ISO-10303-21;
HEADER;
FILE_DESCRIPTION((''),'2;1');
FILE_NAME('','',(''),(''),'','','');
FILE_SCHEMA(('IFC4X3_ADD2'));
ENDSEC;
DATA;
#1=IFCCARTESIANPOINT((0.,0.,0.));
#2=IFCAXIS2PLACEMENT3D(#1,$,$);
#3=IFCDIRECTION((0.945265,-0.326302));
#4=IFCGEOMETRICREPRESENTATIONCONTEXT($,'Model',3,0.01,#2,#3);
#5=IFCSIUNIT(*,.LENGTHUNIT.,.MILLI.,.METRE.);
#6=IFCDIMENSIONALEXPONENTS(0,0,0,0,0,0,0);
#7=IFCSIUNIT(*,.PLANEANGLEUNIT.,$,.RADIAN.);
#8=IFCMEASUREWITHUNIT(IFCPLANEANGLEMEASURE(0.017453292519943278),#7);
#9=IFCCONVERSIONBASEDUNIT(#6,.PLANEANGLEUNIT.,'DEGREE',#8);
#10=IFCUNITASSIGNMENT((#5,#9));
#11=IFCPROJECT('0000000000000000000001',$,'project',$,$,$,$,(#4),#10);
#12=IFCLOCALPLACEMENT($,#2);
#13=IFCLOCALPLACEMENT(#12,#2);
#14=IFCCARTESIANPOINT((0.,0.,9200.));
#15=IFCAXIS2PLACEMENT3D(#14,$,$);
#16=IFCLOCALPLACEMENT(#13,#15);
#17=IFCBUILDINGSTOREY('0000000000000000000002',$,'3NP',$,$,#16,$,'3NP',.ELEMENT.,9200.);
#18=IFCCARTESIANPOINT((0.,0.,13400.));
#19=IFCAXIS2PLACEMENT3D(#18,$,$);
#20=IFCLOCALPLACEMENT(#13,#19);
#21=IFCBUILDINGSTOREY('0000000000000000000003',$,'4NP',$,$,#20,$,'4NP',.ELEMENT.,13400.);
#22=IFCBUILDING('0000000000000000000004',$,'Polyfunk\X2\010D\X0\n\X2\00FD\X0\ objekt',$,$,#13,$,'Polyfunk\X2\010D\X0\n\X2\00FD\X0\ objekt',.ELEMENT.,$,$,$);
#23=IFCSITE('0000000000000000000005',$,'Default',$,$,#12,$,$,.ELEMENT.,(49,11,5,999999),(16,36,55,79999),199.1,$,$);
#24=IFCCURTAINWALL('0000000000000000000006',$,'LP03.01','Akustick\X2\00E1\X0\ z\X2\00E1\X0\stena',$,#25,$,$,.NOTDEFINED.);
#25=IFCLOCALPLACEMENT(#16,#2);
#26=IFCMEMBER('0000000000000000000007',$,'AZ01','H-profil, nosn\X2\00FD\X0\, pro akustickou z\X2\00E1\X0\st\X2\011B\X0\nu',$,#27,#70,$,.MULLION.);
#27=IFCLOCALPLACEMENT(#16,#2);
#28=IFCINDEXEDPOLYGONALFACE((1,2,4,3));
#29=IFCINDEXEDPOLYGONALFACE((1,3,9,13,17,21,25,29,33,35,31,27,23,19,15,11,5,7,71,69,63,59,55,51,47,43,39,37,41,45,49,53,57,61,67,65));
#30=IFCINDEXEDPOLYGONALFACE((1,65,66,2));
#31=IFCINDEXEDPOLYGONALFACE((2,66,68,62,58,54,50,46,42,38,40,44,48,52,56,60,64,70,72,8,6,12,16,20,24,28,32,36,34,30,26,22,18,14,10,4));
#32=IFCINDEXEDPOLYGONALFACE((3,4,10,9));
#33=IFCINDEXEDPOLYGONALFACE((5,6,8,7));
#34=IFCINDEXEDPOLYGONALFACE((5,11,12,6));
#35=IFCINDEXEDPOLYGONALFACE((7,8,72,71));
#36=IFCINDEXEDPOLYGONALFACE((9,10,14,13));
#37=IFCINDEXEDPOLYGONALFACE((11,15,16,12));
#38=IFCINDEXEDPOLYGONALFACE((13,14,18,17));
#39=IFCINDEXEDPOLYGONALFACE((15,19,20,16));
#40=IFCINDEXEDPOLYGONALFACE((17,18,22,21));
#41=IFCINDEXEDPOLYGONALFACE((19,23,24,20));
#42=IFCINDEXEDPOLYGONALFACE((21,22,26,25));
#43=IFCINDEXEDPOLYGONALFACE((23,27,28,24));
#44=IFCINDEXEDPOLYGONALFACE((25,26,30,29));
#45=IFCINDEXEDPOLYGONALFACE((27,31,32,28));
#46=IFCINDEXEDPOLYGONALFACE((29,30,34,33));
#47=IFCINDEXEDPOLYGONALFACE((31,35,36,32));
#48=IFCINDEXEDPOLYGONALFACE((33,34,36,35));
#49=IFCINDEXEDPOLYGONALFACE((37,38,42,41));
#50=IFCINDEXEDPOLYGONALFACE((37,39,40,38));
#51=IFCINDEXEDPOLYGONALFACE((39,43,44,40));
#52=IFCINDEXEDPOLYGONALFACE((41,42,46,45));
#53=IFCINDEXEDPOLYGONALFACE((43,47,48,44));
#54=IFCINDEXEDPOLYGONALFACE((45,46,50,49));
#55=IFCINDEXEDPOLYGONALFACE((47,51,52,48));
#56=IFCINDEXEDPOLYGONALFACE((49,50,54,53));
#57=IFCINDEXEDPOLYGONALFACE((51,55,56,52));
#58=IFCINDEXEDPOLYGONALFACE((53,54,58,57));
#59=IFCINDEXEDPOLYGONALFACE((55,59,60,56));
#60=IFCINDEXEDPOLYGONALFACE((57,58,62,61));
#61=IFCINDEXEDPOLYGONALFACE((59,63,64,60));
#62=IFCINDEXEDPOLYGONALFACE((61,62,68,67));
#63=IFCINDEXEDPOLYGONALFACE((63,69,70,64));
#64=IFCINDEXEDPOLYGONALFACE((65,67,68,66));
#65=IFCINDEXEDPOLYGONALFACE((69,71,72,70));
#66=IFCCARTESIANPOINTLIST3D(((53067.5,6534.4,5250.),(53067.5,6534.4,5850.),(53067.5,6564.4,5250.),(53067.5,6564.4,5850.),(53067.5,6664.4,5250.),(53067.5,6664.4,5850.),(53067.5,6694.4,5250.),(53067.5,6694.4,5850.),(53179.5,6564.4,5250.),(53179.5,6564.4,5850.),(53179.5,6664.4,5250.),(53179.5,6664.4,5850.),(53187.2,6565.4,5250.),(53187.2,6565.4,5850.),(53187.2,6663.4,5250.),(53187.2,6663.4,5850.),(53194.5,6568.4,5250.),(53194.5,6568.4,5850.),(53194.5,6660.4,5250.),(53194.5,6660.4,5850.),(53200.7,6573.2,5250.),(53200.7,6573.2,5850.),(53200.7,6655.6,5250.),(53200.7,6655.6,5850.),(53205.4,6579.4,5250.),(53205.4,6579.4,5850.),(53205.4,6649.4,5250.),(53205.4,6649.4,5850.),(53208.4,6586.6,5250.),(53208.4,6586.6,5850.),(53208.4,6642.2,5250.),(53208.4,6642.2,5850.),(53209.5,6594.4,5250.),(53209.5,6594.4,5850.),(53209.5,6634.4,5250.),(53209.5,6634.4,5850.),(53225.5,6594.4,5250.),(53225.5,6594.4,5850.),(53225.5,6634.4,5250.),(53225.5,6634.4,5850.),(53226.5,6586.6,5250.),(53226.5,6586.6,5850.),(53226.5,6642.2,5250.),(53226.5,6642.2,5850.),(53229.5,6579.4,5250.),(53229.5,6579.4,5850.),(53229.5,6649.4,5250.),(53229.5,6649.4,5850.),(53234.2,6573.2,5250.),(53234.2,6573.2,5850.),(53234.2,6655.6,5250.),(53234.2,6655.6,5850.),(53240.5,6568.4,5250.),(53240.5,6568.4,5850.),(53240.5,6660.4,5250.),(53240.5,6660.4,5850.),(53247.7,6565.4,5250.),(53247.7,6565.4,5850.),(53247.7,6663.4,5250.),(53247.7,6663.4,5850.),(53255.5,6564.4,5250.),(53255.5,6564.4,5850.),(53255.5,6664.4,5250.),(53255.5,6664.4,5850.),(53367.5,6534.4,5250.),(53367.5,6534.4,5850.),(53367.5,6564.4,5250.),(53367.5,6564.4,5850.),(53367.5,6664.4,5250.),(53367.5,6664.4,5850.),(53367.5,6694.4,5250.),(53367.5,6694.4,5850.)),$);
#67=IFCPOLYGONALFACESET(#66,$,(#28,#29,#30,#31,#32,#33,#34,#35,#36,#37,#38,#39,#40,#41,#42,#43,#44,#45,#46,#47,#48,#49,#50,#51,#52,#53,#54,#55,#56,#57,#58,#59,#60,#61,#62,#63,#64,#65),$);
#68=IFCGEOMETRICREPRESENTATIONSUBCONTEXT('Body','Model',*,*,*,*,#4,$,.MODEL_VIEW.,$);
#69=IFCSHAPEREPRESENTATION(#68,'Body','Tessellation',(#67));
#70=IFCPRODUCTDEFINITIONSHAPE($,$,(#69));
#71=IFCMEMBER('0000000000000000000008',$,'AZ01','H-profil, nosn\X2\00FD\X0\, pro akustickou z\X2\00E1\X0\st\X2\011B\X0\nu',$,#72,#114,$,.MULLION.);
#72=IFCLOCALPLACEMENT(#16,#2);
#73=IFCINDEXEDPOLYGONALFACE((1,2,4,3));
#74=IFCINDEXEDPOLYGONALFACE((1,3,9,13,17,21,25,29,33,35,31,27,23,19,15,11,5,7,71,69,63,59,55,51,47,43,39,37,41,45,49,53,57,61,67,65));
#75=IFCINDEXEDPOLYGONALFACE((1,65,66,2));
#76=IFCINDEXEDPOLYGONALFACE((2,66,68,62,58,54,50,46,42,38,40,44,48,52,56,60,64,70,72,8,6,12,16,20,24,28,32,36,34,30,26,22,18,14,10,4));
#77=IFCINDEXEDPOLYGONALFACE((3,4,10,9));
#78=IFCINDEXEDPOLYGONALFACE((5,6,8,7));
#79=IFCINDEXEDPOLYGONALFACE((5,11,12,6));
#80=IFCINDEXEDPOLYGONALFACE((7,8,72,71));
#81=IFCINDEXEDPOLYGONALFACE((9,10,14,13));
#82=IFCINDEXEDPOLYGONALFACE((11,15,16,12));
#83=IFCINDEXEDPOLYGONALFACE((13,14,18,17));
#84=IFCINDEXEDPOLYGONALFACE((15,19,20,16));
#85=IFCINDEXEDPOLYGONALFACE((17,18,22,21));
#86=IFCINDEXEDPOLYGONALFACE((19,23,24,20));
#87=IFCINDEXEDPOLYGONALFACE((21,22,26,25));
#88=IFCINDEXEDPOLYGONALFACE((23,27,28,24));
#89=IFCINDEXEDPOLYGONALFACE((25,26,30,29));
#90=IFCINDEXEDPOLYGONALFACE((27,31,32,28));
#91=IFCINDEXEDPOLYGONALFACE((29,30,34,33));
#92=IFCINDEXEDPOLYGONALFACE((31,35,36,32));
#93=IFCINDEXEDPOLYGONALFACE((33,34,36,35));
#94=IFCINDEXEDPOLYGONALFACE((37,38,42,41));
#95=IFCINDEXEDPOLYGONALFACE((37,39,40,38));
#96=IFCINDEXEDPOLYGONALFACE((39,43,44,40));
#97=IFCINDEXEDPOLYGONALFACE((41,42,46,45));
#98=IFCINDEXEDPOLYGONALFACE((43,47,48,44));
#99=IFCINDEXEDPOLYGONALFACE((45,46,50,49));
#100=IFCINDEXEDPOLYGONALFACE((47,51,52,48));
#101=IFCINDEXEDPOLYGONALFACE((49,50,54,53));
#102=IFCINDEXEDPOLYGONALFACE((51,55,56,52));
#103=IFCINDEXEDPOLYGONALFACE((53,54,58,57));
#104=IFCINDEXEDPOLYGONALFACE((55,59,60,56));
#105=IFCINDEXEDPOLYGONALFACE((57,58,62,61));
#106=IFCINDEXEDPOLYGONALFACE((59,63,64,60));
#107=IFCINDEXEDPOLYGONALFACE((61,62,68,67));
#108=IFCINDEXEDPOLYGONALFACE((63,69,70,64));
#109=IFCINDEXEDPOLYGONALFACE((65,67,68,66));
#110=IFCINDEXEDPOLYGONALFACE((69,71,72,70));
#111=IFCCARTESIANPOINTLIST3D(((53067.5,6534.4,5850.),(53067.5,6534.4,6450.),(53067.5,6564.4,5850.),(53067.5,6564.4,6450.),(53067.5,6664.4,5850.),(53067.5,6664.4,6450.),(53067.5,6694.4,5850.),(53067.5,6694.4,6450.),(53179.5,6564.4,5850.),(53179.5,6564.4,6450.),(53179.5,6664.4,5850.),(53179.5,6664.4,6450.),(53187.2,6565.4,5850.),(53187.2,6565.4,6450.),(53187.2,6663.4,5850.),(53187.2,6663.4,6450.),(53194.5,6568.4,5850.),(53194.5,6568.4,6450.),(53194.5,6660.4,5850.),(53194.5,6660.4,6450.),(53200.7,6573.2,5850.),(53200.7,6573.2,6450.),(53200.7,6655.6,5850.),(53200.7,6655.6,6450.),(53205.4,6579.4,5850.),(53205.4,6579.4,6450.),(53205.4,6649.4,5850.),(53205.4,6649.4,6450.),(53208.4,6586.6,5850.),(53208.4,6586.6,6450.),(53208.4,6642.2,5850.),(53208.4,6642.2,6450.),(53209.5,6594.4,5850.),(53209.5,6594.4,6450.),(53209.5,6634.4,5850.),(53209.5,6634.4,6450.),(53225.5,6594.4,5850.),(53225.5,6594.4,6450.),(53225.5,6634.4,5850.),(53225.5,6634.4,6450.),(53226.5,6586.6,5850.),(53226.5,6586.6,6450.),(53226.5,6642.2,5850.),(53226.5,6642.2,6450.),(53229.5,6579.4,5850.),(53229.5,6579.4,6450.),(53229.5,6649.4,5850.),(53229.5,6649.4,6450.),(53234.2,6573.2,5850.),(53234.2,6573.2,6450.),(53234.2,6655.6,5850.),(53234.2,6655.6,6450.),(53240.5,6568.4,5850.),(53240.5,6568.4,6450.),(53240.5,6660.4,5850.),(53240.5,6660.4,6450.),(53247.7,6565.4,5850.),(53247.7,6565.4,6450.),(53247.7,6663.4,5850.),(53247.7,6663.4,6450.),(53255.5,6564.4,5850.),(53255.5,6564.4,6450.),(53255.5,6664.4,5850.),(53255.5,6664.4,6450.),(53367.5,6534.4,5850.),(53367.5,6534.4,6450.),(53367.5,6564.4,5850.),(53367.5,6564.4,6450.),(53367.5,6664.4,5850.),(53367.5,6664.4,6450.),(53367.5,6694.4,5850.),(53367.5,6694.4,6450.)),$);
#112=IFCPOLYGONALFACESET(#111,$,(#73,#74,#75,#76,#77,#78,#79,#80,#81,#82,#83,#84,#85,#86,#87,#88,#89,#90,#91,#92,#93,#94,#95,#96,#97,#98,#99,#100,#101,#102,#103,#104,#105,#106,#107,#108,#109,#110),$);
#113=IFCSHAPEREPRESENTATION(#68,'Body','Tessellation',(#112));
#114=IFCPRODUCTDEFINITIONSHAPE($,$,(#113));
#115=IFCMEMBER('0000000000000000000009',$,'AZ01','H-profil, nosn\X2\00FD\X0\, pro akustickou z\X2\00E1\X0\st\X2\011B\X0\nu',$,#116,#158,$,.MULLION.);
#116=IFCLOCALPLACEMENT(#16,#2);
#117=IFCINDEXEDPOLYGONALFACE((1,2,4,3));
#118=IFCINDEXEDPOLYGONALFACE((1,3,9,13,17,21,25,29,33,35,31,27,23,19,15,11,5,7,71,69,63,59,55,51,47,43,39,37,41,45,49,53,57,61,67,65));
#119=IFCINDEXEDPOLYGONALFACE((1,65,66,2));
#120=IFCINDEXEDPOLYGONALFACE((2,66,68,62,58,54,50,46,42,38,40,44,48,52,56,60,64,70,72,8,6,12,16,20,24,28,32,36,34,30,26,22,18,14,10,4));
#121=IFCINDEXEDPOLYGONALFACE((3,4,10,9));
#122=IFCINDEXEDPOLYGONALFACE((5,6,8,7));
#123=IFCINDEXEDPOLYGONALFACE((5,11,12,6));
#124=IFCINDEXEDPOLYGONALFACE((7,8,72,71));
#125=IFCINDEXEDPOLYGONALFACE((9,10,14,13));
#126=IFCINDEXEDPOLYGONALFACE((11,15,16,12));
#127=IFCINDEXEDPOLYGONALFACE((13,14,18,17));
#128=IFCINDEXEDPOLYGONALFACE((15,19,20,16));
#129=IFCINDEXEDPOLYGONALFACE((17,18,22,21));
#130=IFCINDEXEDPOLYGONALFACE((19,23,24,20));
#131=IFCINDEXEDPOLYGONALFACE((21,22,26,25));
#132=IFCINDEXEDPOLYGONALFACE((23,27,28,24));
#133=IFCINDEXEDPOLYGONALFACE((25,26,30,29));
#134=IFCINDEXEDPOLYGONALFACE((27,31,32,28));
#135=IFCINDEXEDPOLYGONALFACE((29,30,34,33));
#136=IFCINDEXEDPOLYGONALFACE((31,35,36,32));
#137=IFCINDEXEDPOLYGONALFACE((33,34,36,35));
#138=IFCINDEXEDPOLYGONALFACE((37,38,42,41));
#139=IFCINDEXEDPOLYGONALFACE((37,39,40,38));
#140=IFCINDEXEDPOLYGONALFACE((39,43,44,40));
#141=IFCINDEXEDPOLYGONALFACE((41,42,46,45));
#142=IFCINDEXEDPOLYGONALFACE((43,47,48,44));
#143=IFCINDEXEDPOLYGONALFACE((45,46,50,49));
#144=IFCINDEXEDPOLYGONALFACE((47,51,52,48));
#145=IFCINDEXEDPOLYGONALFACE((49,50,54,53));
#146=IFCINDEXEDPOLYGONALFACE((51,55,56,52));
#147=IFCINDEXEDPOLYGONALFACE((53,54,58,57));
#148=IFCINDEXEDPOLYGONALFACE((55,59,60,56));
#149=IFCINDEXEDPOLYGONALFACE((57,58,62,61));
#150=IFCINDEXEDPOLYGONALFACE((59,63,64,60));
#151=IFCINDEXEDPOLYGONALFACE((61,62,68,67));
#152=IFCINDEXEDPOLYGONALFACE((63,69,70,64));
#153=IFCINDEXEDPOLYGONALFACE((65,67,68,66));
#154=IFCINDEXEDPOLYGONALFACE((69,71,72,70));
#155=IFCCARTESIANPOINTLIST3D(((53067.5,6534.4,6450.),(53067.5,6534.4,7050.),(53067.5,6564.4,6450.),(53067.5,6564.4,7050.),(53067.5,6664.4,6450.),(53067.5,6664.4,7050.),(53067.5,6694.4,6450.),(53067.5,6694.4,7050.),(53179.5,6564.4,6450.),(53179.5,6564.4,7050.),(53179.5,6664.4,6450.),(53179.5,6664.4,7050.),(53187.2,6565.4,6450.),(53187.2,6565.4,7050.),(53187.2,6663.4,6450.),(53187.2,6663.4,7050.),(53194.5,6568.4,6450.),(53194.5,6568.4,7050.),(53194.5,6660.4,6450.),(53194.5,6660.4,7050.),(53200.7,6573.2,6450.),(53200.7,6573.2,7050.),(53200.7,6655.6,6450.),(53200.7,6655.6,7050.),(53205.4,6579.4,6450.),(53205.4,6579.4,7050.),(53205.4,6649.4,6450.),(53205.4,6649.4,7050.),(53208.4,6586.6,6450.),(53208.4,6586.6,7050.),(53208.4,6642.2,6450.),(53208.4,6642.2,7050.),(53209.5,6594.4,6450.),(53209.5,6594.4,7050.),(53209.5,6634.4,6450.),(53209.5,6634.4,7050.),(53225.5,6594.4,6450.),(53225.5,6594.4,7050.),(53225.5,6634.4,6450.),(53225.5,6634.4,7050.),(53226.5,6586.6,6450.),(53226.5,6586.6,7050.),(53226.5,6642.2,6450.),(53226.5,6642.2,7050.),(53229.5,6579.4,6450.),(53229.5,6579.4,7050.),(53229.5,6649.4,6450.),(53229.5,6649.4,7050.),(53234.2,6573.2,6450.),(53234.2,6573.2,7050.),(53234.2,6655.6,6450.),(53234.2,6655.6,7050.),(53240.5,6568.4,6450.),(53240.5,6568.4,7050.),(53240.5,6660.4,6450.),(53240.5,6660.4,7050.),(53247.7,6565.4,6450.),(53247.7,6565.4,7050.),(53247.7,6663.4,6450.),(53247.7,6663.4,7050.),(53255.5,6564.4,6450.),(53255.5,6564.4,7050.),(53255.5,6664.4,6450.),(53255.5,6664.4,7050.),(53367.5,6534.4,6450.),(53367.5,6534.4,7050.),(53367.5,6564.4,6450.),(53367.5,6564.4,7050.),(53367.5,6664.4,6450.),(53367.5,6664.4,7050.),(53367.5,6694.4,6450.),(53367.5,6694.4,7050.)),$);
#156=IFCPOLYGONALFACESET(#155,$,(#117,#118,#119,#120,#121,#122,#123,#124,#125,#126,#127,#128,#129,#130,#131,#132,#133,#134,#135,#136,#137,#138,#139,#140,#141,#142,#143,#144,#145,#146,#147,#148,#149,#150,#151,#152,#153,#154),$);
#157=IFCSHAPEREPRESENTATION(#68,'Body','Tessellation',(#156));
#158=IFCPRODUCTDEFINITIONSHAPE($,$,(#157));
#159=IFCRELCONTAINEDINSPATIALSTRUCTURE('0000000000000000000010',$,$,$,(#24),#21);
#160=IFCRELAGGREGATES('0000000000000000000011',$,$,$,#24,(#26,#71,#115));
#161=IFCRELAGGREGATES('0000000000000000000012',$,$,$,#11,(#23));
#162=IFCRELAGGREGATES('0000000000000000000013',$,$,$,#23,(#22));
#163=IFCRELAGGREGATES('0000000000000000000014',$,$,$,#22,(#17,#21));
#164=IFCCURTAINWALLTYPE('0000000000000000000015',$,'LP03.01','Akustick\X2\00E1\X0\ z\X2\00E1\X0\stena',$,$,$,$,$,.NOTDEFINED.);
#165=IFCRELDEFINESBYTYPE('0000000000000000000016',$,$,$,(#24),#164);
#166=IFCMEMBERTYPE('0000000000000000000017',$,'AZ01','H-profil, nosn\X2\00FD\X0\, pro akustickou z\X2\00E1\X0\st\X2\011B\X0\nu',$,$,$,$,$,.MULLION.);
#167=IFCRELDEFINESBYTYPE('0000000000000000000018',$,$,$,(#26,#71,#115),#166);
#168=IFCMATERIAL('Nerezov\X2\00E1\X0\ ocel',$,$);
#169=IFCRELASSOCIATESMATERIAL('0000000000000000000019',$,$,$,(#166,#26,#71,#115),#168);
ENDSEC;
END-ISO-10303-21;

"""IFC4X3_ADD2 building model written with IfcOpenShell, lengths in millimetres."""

from ifc_helpers import new_model, entity, si_unit, converted_unit, direction, frame, frame_2d, origin, place, context, subcontext, project, spatial, polyline, circle_curve, parameter, trimmed, segment, composite_curve, outline, extrude, source, transform, mapped, material, material_profile, profile_set, profile_usage, type_object, element, aggregate, save


model = new_model("IFC4X3_ADD2")

# Units and contexts
model_context = context("Model", 3, precision=0.01, world=origin(), true_north=direction((0.945265, -0.326302)))
body_context = subcontext(model_context, "Body", "Model", "MODEL_VIEW")
ifc_project = project(units=[si_unit("LENGTHUNIT", "METRE", prefix="MILLI"), converted_unit("PLANEANGLEUNIT", "DEGREE", entity("IfcPlaneAngleMeasure", 0.017453292519943278), si_unit("PLANEANGLEUNIT", "RADIAN"), dimensions=[0, 0, 0, 0, 0, 0, 0])], contexts=[model_context])

# Site, building, storey
site_placement = place(None, origin())
site = spatial("IfcSite", under=ifc_project, at=site_placement, Name="Default", CompositionType="ELEMENT", RefLatitude=(49, 11, 5, 999999), RefLongitude=(16, 36, 55, 79999), RefElevation=199.1)
building_placement = place(site_placement, origin())
building = spatial("IfcBuilding", under=site, at=building_placement, Name="Polyfunkčný objekt", LongName="Polyfunkčný objekt", CompositionType="ELEMENT")
storey_1_placement = place(building_placement, frame((0.0, 0.0, 9200.0)))
storey_1 = spatial("IfcBuildingStorey", under=building, at=storey_1_placement, Name="3NP", LongName="3NP", CompositionType="ELEMENT", Elevation=9200.0)

# Shared definitions
storey_2_placement = place(building_placement, frame((0.0, 0.0, 13400.0)))
storey_2 = spatial("IfcBuildingStorey", under=building, at=storey_2_placement, Name="4NP", LongName="4NP", CompositionType="ELEMENT", Elevation=13400.0)

# Curtain wall, members
curtain_wall_type_1 = type_object("IfcCurtainWallType", Name="LP03.01", Description="Akustická zástena", PredefinedType="NOTDEFINED")
curtain_wall_1_placement = place(storey_2_placement, frame((0.0, 0.0, -13400.0)))
curtain_wall_1 = element("IfcCurtainWall", 1, at=curtain_wall_1_placement, inside=storey_2, type_object=curtain_wall_type_1, Name="LP03.01", Description="Akustická zástena", PredefinedType="NOTDEFINED")
ifc_material_1 = material(Name="Nerezová ocel")
ifc_material_profile_1 = material_profile(ifc_material_1, outline(composite_curve([segment(polyline([(50.0, -150.0), (80.0, -150.0)]), True, "CONTINUOUS"), segment(polyline([(80.0, -150.0), (80.0, 150.0)]), True, "CONTINUOUS"), segment(polyline([(80.0, 150.0), (50.0, 150.0)]), True, "CONTINUOUS"), segment(polyline([(50.0, 150.0), (50.0, 38.0)]), True, "CONTINUOUS"), segment(trimmed(circle_curve(frame_2d((20.0, 38.0), x_axis=(0.0, 1.0)), 30.0), [parameter(180.0)], [parameter(270.0)], True, "PARAMETER"), False, "CONTINUOUS"), segment(polyline([(20.0, 8.0), (-20.0, 8.0)]), True, "CONTINUOUS"), segment(trimmed(circle_curve(frame_2d((-20.0, 38.0), x_axis=(0.0, 1.0)), 30.0), [parameter(90.0)], [parameter(180.0)], True, "PARAMETER"), False, "CONTINUOUS"), segment(polyline([(-50.0, 38.0), (-50.0, 150.0)]), True, "CONTINUOUS"), segment(polyline([(-50.0, 150.0), (-80.0, 150.0)]), True, "CONTINUOUS"), segment(polyline([(-80.0, 150.0), (-80.0, -150.0)]), True, "CONTINUOUS"), segment(polyline([(-80.0, -150.0), (-50.0, -150.0)]), True, "CONTINUOUS"), segment(polyline([(-50.0, -150.0), (-50.0, -38.0)]), True, "CONTINUOUS"), segment(trimmed(circle_curve(frame_2d((-20.0, -38.0), x_axis=(0.0, 1.0)), 30.0), [parameter(0.0)], [parameter(90.0)], True, "PARAMETER"), False, "CONTINUOUS"), segment(polyline([(-20.0, -8.0), (20.0, -8.0)]), True, "CONTINUOUS"), segment(trimmed(circle_curve(frame_2d((20.0, -38.0), x_axis=(0.0, 1.0)), 30.0), [parameter(270.0)], [parameter(0.0)], True, "PARAMETER"), False, "CONTINUOUS"), segment(polyline([(50.0, -38.0), (50.0, -150.0)]), True, "CONTINUOUS")], self_intersect=False)), Name="Profil zástena")
ifc_profile_set_1 = profile_set([ifc_material_profile_1], Name="Profil zástena")
ifc_profile_usage_1 = profile_usage(ifc_profile_set_1)
member_type_1 = type_object("IfcMemberType", Name="AZ01", Description="H-profil, nosný, pro akustickou zástěnu", PredefinedType="MULLION", material=ifc_profile_set_1)
shared_shape_1 = source(origin(), body_context, "Body", "SweptSolid", [
    extrude(outline(composite_curve([segment(polyline([(50.0, -150.0), (80.0, -150.0)]), True, "CONTINUOUS"), segment(polyline([(80.0, -150.0), (80.0, 150.0)]), True, "CONTINUOUS"), segment(polyline([(80.0, 150.0), (50.0, 150.0)]), True, "CONTINUOUS"), segment(polyline([(50.0, 150.0), (50.0, 38.0)]), True, "CONTINUOUS"), segment(trimmed(circle_curve(frame_2d((20.0, 38.0), x_axis=(0.0, 1.0)), 30.0), [parameter(180.0)], [parameter(270.0)], True, "PARAMETER"), False, "CONTINUOUS"), segment(polyline([(20.0, 8.0), (-20.0, 8.0)]), True, "CONTINUOUS"), segment(trimmed(circle_curve(frame_2d((-20.0, 38.0), x_axis=(0.0, 1.0)), 30.0), [parameter(90.0)], [parameter(180.0)], True, "PARAMETER"), False, "CONTINUOUS"), segment(polyline([(-50.0, 38.0), (-50.0, 150.0)]), True, "CONTINUOUS"), segment(polyline([(-50.0, 150.0), (-80.0, 150.0)]), True, "CONTINUOUS"), segment(polyline([(-80.0, 150.0), (-80.0, -150.0)]), True, "CONTINUOUS"), segment(polyline([(-80.0, -150.0), (-50.0, -150.0)]), True, "CONTINUOUS"), segment(polyline([(-50.0, -150.0), (-50.0, -38.0)]), True, "CONTINUOUS"), segment(trimmed(circle_curve(frame_2d((-20.0, -38.0), x_axis=(0.0, 1.0)), 30.0), [parameter(0.0)], [parameter(90.0)], True, "PARAMETER"), False, "CONTINUOUS"), segment(polyline([(-20.0, -8.0), (20.0, -8.0)]), True, "CONTINUOUS"), segment(trimmed(circle_curve(frame_2d((20.0, -38.0), x_axis=(0.0, 1.0)), 30.0), [parameter(270.0)], [parameter(0.0)], True, "PARAMETER"), False, "CONTINUOUS"), segment(polyline([(50.0, -38.0), (50.0, -150.0)]), True, "CONTINUOUS")], self_intersect=False)), frame((0.0, 0.0, -600.0), z_axis=(0.0, 0.0, 1.0), x_axis=(0.0, -1.0, 0.0)), (0.0, 0.0, 1.0), 600.0),
])
member_1_placement = place(curtain_wall_1_placement, frame((53217.5, 6614.4, 14450.0), z_axis=(0.0, 0.0, -1.0), x_axis=(1.0, 0.0, 0.0)))
member_1 = element("IfcMember", 2, at=member_1_placement, type_object=member_type_1, material=ifc_profile_usage_1, Name="AZ01", Description="H-profil, nosný, pro akustickou zástěnu", PredefinedType="MULLION", context=body_context, shape_type="MappedRepresentation", body=[
    mapped(shared_shape_1, transform((0.0, 0.0, 0.0), scale=1.0)),
])
member_2_placement = place(curtain_wall_1_placement, frame((53217.5, 6614.4, 15050.0), z_axis=(0.0, 0.0, -1.0), x_axis=(1.0, 0.0, 0.0)))
member_2 = element("IfcMember", 3, at=member_2_placement, type_object=member_type_1, material=ifc_profile_usage_1, Name="AZ01", Description="H-profil, nosný, pro akustickou zástěnu", PredefinedType="MULLION", context=body_context, shape_type="MappedRepresentation", body=[
    mapped(shared_shape_1, transform((0.0, 0.0, 0.0), scale=1.0)),
])
member_3_placement = place(curtain_wall_1_placement, frame((53217.5, 6614.4, 15650.0), z_axis=(0.0, 0.0, -1.0), x_axis=(1.0, 0.0, 0.0)))
member_3 = element("IfcMember", 4, at=member_3_placement, type_object=member_type_1, material=ifc_profile_usage_1, Name="AZ01", Description="H-profil, nosný, pro akustickou zástěnu", PredefinedType="MULLION", context=body_context, shape_type="MappedRepresentation", body=[
    mapped(shared_shape_1, transform((0.0, 0.0, 0.0), scale=1.0)),
])
aggregate(curtain_wall_1, [member_1, member_2, member_3])

save(model, "model.ifc")
